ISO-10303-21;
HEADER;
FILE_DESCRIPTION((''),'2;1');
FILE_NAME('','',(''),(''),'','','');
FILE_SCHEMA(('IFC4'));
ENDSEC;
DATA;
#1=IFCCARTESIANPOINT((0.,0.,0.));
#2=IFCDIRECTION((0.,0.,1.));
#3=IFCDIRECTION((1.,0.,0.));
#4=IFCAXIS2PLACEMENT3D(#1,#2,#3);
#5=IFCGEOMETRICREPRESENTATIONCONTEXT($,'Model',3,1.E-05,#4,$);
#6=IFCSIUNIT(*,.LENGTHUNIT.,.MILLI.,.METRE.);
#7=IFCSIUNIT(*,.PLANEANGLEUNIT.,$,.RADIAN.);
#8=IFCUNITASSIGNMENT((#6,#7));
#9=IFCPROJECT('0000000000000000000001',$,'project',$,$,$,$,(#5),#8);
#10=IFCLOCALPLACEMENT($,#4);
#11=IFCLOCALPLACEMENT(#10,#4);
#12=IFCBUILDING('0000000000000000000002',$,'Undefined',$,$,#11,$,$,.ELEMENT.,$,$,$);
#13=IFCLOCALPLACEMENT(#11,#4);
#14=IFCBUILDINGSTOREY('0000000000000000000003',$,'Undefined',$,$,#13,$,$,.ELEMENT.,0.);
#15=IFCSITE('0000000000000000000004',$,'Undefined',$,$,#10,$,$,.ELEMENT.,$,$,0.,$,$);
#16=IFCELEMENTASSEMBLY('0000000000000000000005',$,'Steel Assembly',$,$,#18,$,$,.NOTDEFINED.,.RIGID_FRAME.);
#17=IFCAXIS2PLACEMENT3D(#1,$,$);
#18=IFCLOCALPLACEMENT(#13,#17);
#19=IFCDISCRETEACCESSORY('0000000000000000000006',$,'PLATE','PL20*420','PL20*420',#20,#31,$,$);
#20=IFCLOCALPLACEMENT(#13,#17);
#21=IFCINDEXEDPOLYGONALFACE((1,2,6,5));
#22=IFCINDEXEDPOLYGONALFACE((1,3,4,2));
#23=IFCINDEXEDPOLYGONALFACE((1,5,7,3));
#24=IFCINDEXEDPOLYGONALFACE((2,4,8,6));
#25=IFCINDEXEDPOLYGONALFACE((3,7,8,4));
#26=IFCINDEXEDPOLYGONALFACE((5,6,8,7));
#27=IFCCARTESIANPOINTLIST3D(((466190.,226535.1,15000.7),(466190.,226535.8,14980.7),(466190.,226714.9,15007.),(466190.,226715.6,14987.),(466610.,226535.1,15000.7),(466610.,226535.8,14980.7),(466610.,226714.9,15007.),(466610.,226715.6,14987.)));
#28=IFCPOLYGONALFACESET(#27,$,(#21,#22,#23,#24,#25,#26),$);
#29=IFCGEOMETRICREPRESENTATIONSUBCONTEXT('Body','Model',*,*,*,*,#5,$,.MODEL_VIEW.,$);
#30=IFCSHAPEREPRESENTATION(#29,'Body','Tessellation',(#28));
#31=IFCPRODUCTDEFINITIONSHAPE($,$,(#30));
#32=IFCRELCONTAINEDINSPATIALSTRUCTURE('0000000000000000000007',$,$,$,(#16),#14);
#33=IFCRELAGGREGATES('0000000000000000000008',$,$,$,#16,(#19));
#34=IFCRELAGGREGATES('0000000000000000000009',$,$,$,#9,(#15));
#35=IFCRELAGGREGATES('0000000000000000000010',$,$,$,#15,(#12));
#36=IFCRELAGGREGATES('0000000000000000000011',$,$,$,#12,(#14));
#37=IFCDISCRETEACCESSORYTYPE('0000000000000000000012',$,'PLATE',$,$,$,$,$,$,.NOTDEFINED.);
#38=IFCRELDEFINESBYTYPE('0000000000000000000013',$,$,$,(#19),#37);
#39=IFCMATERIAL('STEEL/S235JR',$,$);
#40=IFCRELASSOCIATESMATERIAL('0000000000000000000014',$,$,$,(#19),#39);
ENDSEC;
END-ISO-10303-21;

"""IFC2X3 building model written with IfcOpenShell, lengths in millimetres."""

from ifc_helpers import new_model, si_unit, frame, origin_with_axes, place, context, subcontext, project, spatial, polyline, outline, extrude, material, type_object, element, aggregate, save


model = new_model("IFC2X3")

# Units and contexts
model_context = context("Model", 3, precision=1e-05, world=origin_with_axes())
body_context = subcontext(model_context, "Body", "Model", "MODEL_VIEW")
ifc_project = project(units=[si_unit("LENGTHUNIT", "METRE", prefix="MILLI"), si_unit("PLANEANGLEUNIT", "RADIAN")], contexts=[model_context])

# Site, building, storey
site_placement = place(None, origin_with_axes())
site = spatial("IfcSite", under=ifc_project, at=site_placement, Name="Undefined", CompositionType="ELEMENT", RefElevation=0.0)
building_placement = place(site_placement, origin_with_axes())
building = spatial("IfcBuilding", under=site, at=building_placement, Name="Undefined", CompositionType="ELEMENT")
storey_placement = place(building_placement, origin_with_axes())
storey = spatial("IfcBuildingStorey", under=building, at=storey_placement, Name="Undefined", CompositionType="ELEMENT", Elevation=0.0)

# Shared definitions
ifc_material_1 = material(Name="STEEL/S235JR")
discrete_accessory_type_1 = type_object("IfcDiscreteAccessoryType", Name="PLATE")

# Element assembly, discrete accessory
assembly_1_placement = place(storey_placement, origin_with_axes())
assembly_1 = element("IfcElementAssembly", 1, at=assembly_1_placement, inside=storey, Name="Steel Assembly", AssemblyPlace="NOTDEFINED", PredefinedType="RIGID_FRAME")
discrete_accessory_1_placement = place(assembly_1_placement, frame((466400.0, 226535.4, 14990.7), z_axis=(0.0, 0.034899, -0.999391), x_axis=(0.0, 0.999391, 0.034899)))
discrete_accessory_1 = element("IfcDiscreteAccessory", 2, at=discrete_accessory_1_placement, type_object=discrete_accessory_type_1, material=ifc_material_1, Name="PLATE", Description="PL20*420", ObjectType="PL20*420", context=body_context, shape_type="SweptSolid", body=[
    extrude(outline(polyline([(0.0, 210.0), (180.0, 210.0), (180.0, -210.0), (0.0, -210.0), (0.0, 210.0)])), frame((0.0, 0.0, -10.0), z_axis=(0.0, 0.0, 1.0), x_axis=(1.0, 0.0, 0.0)), (0.0, 0.0, 1.0), 20.0),
])
aggregate(assembly_1, [discrete_accessory_1])

save(model, "model.ifc")
